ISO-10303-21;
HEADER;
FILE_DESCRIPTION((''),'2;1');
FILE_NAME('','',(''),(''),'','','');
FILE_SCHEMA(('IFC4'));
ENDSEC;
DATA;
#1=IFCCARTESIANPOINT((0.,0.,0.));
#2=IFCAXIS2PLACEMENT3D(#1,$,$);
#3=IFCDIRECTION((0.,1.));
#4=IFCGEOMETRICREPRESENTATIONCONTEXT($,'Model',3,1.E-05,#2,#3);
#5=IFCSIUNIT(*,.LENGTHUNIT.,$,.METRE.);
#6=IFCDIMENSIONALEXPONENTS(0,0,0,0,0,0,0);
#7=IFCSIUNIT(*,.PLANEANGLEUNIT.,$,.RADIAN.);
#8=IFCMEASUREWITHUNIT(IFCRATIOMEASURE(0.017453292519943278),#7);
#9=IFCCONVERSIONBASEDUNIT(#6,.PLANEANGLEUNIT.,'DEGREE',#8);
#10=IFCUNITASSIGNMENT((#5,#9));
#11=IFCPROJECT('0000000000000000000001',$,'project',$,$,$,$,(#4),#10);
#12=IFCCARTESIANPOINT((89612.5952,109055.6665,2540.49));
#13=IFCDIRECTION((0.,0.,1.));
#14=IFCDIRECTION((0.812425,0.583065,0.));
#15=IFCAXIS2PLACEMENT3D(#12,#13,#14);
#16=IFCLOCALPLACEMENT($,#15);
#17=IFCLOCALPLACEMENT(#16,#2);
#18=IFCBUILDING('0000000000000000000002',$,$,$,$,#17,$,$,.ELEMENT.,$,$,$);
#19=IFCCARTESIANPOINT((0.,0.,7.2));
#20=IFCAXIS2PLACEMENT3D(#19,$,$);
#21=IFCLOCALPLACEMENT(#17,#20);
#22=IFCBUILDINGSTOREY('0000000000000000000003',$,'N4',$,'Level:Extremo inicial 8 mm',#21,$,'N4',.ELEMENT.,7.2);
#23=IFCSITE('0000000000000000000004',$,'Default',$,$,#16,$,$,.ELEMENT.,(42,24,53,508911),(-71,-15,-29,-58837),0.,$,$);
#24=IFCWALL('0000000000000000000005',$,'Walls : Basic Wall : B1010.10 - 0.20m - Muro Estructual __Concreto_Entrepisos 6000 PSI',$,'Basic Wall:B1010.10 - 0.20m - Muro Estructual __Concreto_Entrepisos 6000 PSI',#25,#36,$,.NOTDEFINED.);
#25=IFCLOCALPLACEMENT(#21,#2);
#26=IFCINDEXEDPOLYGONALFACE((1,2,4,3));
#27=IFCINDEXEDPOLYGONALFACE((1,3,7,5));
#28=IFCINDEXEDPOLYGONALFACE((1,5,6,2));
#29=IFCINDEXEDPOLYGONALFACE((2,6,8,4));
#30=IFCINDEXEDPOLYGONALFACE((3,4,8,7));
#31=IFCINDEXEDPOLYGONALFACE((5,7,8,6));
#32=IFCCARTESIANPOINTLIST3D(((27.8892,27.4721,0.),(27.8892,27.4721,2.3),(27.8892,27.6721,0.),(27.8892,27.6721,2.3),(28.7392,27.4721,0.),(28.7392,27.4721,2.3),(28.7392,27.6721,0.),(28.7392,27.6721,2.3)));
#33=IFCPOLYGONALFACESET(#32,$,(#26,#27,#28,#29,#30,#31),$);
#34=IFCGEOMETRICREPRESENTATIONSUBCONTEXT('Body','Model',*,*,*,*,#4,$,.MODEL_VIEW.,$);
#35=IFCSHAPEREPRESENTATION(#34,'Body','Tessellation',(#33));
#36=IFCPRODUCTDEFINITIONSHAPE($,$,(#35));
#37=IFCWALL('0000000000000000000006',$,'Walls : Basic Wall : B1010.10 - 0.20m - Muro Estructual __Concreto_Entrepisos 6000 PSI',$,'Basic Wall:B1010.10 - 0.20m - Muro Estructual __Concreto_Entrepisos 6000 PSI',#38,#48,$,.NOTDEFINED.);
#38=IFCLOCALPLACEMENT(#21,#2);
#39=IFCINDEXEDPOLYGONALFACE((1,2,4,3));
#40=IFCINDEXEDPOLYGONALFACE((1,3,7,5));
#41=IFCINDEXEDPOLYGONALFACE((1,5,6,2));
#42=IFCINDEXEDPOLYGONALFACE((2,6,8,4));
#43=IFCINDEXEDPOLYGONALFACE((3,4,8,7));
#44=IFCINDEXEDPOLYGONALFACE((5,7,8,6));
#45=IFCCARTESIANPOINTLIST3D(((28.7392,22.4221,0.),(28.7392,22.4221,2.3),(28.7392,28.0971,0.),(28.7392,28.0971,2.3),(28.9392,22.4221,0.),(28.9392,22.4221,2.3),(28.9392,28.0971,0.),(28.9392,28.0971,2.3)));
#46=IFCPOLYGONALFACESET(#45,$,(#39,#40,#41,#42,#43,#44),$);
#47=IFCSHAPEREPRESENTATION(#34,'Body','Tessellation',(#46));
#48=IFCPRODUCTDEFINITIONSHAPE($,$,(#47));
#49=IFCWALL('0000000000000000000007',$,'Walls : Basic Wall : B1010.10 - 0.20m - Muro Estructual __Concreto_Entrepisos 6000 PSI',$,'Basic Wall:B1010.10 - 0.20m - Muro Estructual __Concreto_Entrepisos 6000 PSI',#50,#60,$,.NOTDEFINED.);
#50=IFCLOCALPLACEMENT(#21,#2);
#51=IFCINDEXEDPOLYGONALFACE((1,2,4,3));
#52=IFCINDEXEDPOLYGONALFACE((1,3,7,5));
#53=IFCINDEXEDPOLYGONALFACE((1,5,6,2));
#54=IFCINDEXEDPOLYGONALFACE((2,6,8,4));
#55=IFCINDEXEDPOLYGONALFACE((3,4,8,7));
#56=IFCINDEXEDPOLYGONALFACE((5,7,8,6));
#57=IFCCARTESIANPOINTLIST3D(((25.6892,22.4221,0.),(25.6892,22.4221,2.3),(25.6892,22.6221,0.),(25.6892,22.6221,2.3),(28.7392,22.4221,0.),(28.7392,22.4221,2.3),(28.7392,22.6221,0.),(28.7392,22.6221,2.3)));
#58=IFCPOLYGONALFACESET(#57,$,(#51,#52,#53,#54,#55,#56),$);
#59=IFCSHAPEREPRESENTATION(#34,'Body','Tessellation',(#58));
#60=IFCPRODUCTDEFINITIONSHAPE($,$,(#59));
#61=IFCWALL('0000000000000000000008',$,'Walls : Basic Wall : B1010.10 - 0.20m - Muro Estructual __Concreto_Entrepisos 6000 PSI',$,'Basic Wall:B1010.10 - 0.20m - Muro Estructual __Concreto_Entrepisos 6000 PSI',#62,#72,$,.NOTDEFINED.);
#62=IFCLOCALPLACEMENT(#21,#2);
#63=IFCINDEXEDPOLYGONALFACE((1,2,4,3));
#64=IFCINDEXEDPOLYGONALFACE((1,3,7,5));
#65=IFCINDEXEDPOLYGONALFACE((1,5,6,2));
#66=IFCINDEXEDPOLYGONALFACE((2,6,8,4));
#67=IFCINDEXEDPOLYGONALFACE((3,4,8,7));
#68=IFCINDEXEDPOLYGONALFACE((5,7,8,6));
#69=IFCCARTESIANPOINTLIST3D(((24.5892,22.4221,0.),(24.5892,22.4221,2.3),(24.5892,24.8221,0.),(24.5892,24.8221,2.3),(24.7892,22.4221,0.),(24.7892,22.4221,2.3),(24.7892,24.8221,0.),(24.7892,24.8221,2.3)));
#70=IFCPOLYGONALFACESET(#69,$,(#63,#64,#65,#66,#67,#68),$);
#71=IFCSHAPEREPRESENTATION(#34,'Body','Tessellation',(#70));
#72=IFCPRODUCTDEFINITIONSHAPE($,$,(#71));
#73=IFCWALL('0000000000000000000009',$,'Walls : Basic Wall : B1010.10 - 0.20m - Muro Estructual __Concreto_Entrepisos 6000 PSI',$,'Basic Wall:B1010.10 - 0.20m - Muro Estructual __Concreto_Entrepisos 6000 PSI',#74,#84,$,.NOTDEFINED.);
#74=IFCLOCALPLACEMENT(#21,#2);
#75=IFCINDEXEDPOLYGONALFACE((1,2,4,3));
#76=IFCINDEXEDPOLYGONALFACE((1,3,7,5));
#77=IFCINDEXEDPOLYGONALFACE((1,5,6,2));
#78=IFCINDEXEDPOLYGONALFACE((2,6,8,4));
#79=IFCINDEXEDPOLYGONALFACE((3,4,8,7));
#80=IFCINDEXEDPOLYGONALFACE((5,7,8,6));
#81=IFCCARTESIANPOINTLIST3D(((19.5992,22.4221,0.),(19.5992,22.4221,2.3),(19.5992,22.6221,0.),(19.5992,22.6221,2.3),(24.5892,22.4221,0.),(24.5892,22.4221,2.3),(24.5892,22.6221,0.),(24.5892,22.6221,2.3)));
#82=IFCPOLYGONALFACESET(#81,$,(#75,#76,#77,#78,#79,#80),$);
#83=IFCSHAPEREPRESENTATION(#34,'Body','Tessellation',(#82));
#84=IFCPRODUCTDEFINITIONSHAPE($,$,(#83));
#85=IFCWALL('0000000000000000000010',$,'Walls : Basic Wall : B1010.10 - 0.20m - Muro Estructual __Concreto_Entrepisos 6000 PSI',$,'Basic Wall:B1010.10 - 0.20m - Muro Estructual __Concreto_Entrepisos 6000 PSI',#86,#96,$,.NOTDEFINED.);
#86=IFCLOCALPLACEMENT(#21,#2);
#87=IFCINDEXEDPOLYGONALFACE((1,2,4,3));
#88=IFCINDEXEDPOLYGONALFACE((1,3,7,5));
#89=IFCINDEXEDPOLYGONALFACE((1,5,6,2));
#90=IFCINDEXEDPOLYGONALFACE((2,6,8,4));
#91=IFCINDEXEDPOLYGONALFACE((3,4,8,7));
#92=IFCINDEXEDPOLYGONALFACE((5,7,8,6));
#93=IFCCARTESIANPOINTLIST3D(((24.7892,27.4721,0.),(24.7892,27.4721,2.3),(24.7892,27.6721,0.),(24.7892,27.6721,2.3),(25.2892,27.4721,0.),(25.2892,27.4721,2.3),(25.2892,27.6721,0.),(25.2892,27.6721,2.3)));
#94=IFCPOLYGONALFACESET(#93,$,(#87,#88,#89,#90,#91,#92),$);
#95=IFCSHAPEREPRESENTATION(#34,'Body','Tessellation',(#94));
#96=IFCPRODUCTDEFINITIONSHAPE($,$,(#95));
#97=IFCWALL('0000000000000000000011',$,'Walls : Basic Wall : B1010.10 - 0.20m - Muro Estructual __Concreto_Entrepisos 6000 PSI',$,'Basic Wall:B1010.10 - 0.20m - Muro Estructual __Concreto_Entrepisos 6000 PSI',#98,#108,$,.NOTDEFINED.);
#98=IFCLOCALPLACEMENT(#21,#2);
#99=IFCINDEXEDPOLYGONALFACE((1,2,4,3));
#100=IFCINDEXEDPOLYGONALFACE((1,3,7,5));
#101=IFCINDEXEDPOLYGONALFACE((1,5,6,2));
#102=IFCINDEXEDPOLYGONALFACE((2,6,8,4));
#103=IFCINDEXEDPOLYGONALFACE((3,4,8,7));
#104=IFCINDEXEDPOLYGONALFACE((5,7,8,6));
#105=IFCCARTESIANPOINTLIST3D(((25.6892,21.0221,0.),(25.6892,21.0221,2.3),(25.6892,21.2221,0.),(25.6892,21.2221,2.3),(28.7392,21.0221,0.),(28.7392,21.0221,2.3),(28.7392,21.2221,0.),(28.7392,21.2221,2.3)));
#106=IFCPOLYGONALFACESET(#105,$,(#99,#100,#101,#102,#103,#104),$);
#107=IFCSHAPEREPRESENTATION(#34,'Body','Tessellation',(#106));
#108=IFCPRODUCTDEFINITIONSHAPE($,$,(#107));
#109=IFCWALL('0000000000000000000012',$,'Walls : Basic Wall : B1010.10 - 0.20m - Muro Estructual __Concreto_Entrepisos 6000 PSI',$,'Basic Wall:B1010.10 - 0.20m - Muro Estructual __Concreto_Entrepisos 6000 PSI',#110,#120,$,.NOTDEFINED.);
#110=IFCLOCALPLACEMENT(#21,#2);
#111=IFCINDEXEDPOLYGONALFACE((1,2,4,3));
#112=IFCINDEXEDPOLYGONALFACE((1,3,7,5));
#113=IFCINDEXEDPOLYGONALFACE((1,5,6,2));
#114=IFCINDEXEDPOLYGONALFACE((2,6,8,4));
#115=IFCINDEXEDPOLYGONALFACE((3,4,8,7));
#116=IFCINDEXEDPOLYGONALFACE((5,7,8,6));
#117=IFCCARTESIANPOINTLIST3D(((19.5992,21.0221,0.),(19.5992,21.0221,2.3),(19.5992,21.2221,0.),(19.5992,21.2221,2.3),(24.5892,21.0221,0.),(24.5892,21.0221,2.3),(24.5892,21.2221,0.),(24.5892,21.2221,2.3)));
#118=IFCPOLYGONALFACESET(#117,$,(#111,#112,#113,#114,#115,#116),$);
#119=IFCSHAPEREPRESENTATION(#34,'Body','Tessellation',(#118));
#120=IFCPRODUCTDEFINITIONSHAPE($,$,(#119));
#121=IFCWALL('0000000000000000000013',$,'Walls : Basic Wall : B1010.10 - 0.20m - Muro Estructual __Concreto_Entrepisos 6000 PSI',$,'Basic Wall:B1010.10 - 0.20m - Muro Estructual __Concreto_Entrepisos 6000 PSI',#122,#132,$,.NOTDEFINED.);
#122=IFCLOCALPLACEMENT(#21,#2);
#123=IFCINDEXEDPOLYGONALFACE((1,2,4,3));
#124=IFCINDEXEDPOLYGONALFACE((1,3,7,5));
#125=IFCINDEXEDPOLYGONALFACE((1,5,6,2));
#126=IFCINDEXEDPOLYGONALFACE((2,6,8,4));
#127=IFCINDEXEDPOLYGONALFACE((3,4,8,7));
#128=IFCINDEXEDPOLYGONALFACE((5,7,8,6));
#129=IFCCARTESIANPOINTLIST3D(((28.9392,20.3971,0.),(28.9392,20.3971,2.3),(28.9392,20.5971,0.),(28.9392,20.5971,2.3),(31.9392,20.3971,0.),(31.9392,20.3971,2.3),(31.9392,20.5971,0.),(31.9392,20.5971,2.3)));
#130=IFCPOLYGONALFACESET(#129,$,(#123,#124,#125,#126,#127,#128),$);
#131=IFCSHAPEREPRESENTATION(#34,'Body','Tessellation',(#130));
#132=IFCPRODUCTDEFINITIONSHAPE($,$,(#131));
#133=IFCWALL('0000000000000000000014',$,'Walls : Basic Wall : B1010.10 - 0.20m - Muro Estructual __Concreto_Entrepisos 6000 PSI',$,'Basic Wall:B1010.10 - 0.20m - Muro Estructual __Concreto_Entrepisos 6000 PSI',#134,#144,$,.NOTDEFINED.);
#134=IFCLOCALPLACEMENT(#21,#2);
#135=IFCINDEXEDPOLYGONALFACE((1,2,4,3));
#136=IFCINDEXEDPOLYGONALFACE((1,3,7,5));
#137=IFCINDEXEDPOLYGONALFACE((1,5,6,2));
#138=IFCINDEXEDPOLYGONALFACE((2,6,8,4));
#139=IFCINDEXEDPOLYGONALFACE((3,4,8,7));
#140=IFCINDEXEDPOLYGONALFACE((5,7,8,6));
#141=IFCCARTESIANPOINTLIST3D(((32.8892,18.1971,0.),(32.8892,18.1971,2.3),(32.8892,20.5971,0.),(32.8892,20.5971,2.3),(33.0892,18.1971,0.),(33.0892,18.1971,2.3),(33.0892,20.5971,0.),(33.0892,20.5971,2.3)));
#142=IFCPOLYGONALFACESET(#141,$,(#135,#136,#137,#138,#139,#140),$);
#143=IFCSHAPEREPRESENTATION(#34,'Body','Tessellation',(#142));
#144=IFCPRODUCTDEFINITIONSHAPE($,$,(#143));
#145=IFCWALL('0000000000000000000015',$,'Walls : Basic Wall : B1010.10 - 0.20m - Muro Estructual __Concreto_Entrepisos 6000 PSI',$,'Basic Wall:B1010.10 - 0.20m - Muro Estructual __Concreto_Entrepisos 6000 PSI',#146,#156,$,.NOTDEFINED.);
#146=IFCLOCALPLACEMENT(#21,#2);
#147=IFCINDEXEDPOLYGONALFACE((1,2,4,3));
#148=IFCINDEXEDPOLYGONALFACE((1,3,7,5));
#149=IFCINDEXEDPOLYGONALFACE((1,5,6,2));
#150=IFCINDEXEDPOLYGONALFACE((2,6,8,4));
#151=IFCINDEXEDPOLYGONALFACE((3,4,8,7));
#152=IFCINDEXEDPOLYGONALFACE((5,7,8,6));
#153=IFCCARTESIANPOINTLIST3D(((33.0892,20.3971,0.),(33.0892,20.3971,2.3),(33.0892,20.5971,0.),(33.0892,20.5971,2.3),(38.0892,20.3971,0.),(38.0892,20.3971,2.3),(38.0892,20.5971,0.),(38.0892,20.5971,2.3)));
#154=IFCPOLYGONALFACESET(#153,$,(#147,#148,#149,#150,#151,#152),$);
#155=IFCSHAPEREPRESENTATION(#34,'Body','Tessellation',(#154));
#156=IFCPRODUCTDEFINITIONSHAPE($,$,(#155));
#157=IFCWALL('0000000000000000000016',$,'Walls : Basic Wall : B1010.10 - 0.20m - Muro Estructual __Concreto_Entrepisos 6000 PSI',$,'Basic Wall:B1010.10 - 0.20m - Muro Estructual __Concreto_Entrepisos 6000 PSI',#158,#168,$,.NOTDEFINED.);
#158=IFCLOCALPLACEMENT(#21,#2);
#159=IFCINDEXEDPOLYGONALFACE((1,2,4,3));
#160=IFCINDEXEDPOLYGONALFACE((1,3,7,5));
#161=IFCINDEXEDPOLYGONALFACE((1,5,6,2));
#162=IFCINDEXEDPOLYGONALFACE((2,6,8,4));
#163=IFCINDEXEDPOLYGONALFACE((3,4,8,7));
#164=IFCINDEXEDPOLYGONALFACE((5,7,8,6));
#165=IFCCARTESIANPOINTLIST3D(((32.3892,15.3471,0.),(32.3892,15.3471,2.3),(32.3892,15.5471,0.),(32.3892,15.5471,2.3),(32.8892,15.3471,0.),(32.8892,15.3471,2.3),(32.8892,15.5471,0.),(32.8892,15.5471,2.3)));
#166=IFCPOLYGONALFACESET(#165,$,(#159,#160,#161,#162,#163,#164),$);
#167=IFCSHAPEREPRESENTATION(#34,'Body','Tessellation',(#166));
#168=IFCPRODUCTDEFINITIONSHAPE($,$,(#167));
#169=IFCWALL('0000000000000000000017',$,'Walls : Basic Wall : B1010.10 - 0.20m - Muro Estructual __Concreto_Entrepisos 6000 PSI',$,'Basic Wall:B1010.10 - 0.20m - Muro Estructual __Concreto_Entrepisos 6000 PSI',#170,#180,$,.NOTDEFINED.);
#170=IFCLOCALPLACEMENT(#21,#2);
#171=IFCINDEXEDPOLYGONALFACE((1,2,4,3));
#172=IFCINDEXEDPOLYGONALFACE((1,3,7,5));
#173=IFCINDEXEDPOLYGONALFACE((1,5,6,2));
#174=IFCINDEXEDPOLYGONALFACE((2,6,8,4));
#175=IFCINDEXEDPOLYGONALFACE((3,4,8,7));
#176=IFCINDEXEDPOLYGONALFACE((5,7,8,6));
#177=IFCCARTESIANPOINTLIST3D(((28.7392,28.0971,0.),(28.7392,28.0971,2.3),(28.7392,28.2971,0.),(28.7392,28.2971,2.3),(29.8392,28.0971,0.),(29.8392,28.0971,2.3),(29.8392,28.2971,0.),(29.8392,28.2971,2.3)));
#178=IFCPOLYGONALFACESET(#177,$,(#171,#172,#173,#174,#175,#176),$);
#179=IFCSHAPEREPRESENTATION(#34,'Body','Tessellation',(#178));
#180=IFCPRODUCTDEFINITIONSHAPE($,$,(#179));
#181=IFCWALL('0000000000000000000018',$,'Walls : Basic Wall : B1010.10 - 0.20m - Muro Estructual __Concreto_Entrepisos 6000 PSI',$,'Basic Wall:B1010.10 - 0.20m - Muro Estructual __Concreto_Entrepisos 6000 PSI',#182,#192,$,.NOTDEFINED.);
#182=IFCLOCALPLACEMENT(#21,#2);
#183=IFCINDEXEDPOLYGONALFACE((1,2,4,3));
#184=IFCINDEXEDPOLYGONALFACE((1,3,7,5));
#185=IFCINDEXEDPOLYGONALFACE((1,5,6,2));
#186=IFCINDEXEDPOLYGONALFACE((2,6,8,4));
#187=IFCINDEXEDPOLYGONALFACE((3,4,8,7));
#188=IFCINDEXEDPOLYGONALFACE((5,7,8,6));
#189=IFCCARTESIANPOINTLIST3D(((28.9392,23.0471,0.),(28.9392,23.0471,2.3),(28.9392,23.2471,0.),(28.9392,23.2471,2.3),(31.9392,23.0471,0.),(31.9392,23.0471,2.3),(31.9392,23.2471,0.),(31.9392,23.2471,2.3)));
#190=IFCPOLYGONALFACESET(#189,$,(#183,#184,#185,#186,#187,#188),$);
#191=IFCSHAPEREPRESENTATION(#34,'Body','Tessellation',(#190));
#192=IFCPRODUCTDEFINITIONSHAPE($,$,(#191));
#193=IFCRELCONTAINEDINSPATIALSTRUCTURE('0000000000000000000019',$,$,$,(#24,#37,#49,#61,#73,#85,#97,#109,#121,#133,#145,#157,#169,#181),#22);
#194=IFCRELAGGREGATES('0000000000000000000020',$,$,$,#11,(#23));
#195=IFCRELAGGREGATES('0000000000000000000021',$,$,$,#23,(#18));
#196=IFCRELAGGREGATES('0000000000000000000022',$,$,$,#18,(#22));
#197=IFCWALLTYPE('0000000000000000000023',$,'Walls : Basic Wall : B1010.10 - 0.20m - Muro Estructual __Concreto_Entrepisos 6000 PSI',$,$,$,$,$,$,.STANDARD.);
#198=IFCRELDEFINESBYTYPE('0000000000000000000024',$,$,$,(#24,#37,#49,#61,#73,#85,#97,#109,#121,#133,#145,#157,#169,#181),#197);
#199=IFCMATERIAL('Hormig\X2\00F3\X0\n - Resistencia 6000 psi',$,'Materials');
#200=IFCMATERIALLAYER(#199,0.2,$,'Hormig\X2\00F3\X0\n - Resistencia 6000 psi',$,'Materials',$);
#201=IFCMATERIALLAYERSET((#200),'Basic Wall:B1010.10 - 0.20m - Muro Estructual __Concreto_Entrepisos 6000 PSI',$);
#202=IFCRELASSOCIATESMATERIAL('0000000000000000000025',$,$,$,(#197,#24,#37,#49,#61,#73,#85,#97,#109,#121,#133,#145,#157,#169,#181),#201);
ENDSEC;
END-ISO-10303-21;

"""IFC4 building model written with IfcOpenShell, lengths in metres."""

from ifc_helpers import new_model, entity, si_unit, converted_unit, direction, frame, frame_2d, origin, place, context, subcontext, project, spatial, rectangle, extrude, material, layer, layer_set, layer_usage, type_object, element, save


model = new_model("IFC4")

# Units and contexts
model_context = context("Model", 3, precision=1e-05, world=origin(), true_north=direction((0.0, 1.0)))
body_context = subcontext(model_context, "Body", "Model", "MODEL_VIEW")
ifc_project = project(units=[si_unit("LENGTHUNIT", "METRE"), converted_unit("PLANEANGLEUNIT", "DEGREE", entity("IfcRatioMeasure", 0.017453292519943278), si_unit("PLANEANGLEUNIT", "RADIAN"), dimensions=[0, 0, 0, 0, 0, 0, 0])], contexts=[model_context])

# Site, building, storey
site_placement = place(None, frame((89612.5952, 109055.6665, 2540.49), z_axis=(0.0, 0.0, 1.0), x_axis=(0.812425, 0.583065, 0.0)))
site = spatial("IfcSite", under=ifc_project, at=site_placement, Name="Default", CompositionType="ELEMENT", RefLatitude=(42, 24, 53, 508911), RefLongitude=(-71, -15, -29, -58837), RefElevation=0.0)
building_placement = place(site_placement, origin())
building = spatial("IfcBuilding", under=site, at=building_placement, CompositionType="ELEMENT")
storey_placement = place(building_placement, frame((0.0, 0.0, 7.2)))
storey = spatial("IfcBuildingStorey", under=building, at=storey_placement, Name="N4", ObjectType="Level:Extremo inicial 8 mm", LongName="N4", CompositionType="ELEMENT", Elevation=7.2)

# Walls
ifc_material = material(Name="Hormigón - Resistencia 6000 psi", Category="Materials")
ifc_layer_1 = layer(ifc_material, 0.2, Name="Hormigón - Resistencia 6000 psi", Category="Materials")
ifc_layer_set_1 = layer_set([ifc_layer_1], Name="Basic Wall:B1010.10 - 0.20m - Muro Estructual __Concreto_Entrepisos 6000 PSI")
ifc_layer_usage_1 = layer_usage(ifc_layer_set_1, "AXIS2", "NEGATIVE", 0.1)
wall_type_1 = type_object("IfcWallType", Name="Walls : Basic Wall : B1010.10 - 0.20m - Muro Estructual __Concreto_Entrepisos 6000 PSI", PredefinedType="STANDARD", material=ifc_layer_set_1)
wall_1_placement = place(storey_placement, frame((27.8892, 27.5721, 0.0)))
element("IfcWall", 1, at=wall_1_placement, inside=storey, type_object=wall_type_1, material=ifc_layer_usage_1, Name="Walls : Basic Wall : B1010.10 - 0.20m - Muro Estructual __Concreto_Entrepisos 6000 PSI", ObjectType="Basic Wall:B1010.10 - 0.20m - Muro Estructual __Concreto_Entrepisos 6000 PSI", PredefinedType="NOTDEFINED", context=body_context, shape_type="SweptSolid", body=[
    extrude(rectangle(XDim=0.85, YDim=0.2, at=frame_2d((0.425, 0.0), x_axis=(-1.0, 0.0))), origin(), (0.0, 0.0, 1.0), 2.3),
])
ifc_layer_usage_2 = layer_usage(ifc_layer_set_1, "AXIS2", "NEGATIVE", 0.1)
wall_2_placement = place(storey_placement, frame((28.8392, 28.0971, 0.0), z_axis=(0.0, 0.0, 1.0), x_axis=(0.0, -1.0, 0.0)))
element("IfcWall", 2, at=wall_2_placement, inside=storey, type_object=wall_type_1, material=ifc_layer_usage_2, Name="Walls : Basic Wall : B1010.10 - 0.20m - Muro Estructual __Concreto_Entrepisos 6000 PSI", ObjectType="Basic Wall:B1010.10 - 0.20m - Muro Estructual __Concreto_Entrepisos 6000 PSI", PredefinedType="NOTDEFINED", context=body_context, shape_type="SweptSolid", body=[
    extrude(rectangle(XDim=5.675, YDim=0.2, at=frame_2d((2.8375, 0.0), x_axis=(-1.0, 0.0))), origin(), (0.0, 0.0, 1.0), 2.3),
])
ifc_layer_usage_3 = layer_usage(ifc_layer_set_1, "AXIS2", "NEGATIVE", 0.1)
wall_3_placement = place(storey_placement, frame((28.7392, 22.5221, 0.0), z_axis=(0.0, 0.0, 1.0), x_axis=(-1.0, 0.0, 0.0)))
element("IfcWall", 3, at=wall_3_placement, inside=storey, type_object=wall_type_1, material=ifc_layer_usage_3, Name="Walls : Basic Wall : B1010.10 - 0.20m - Muro Estructual __Concreto_Entrepisos 6000 PSI", ObjectType="Basic Wall:B1010.10 - 0.20m - Muro Estructual __Concreto_Entrepisos 6000 PSI", PredefinedType="NOTDEFINED", context=body_context, shape_type="SweptSolid", body=[
    extrude(rectangle(XDim=3.05, YDim=0.2, at=frame_2d((1.525, 0.0), x_axis=(-1.0, 0.0))), origin(), (0.0, 0.0, 1.0), 2.3),
])
ifc_layer_usage_4 = layer_usage(ifc_layer_set_1, "AXIS2", "NEGATIVE", 0.1)
wall_4_placement = place(storey_placement, frame((24.6892, 24.8221, 0.0), z_axis=(0.0, 0.0, 1.0), x_axis=(0.0, -1.0, 0.0)))
element("IfcWall", 4, at=wall_4_placement, inside=storey, type_object=wall_type_1, material=ifc_layer_usage_4, Name="Walls : Basic Wall : B1010.10 - 0.20m - Muro Estructual __Concreto_Entrepisos 6000 PSI", ObjectType="Basic Wall:B1010.10 - 0.20m - Muro Estructual __Concreto_Entrepisos 6000 PSI", PredefinedType="NOTDEFINED", context=body_context, shape_type="SweptSolid", body=[
    extrude(rectangle(XDim=2.4, YDim=0.2, at=frame_2d((1.2, 0.0), x_axis=(-1.0, 0.0))), origin(), (0.0, 0.0, 1.0), 2.3),
])
ifc_layer_usage_5 = layer_usage(ifc_layer_set_1, "AXIS2", "NEGATIVE", 0.1)
wall_5_placement = place(storey_placement, frame((24.5892, 22.5221, 0.0), z_axis=(0.0, 0.0, 1.0), x_axis=(-1.0, 0.0, 0.0)))
element("IfcWall", 5, at=wall_5_placement, inside=storey, type_object=wall_type_1, material=ifc_layer_usage_5, Name="Walls : Basic Wall : B1010.10 - 0.20m - Muro Estructual __Concreto_Entrepisos 6000 PSI", ObjectType="Basic Wall:B1010.10 - 0.20m - Muro Estructual __Concreto_Entrepisos 6000 PSI", PredefinedType="NOTDEFINED", context=body_context, shape_type="SweptSolid", body=[
    extrude(rectangle(XDim=4.99, YDim=0.2, at=frame_2d((2.495, 0.0), x_axis=(-1.0, 0.0))), origin(), (0.0, 0.0, 1.0), 2.3),
])
ifc_layer_usage_6 = layer_usage(ifc_layer_set_1, "AXIS2", "NEGATIVE", 0.1)
wall_6_placement = place(storey_placement, frame((25.2892, 27.5721, 0.0), z_axis=(0.0, 0.0, 1.0), x_axis=(-1.0, 0.0, 0.0)))
element("IfcWall", 6, at=wall_6_placement, inside=storey, type_object=wall_type_1, material=ifc_layer_usage_6, Name="Walls : Basic Wall : B1010.10 - 0.20m - Muro Estructual __Concreto_Entrepisos 6000 PSI", ObjectType="Basic Wall:B1010.10 - 0.20m - Muro Estructual __Concreto_Entrepisos 6000 PSI", PredefinedType="NOTDEFINED", context=body_context, shape_type="SweptSolid", body=[
    extrude(rectangle(XDim=0.5, YDim=0.2, at=frame_2d((0.25, 0.0), x_axis=(-1.0, 0.0))), origin(), (0.0, 0.0, 1.0), 2.3),
])
ifc_layer_usage_7 = layer_usage(ifc_layer_set_1, "AXIS2", "POSITIVE", -0.1)
wall_7_placement = place(storey_placement, frame((28.7392, 21.1221, 0.0), z_axis=(0.0, 0.0, 1.0), x_axis=(-1.0, 0.0, 0.0)))
element("IfcWall", 7, at=wall_7_placement, inside=storey, type_object=wall_type_1, material=ifc_layer_usage_7, Name="Walls : Basic Wall : B1010.10 - 0.20m - Muro Estructual __Concreto_Entrepisos 6000 PSI", ObjectType="Basic Wall:B1010.10 - 0.20m - Muro Estructual __Concreto_Entrepisos 6000 PSI", PredefinedType="NOTDEFINED", context=body_context, shape_type="SweptSolid", body=[
    extrude(rectangle(XDim=3.05, YDim=0.2, at=frame_2d((1.525, 0.0), x_axis=(-1.0, 0.0))), origin(), (0.0, 0.0, 1.0), 2.3),
])
ifc_layer_usage_8 = layer_usage(ifc_layer_set_1, "AXIS2", "POSITIVE", -0.1)
wall_8_placement = place(storey_placement, frame((24.5892, 21.1221, 0.0), z_axis=(0.0, 0.0, 1.0), x_axis=(-1.0, 0.0, 0.0)))
element("IfcWall", 8, at=wall_8_placement, inside=storey, type_object=wall_type_1, material=ifc_layer_usage_8, Name="Walls : Basic Wall : B1010.10 - 0.20m - Muro Estructual __Concreto_Entrepisos 6000 PSI", ObjectType="Basic Wall:B1010.10 - 0.20m - Muro Estructual __Concreto_Entrepisos 6000 PSI", PredefinedType="NOTDEFINED", context=body_context, shape_type="SweptSolid", body=[
    extrude(rectangle(XDim=4.99, YDim=0.2, at=frame_2d((2.495, 0.0), x_axis=(-1.0, 0.0))), origin(), (0.0, 0.0, 1.0), 2.3),
])
ifc_layer_usage_9 = layer_usage(ifc_layer_set_1, "AXIS2", "NEGATIVE", 0.1)
wall_9_placement = place(storey_placement, frame((28.9392, 20.4971, 0.0)))
element("IfcWall", 9, at=wall_9_placement, inside=storey, type_object=wall_type_1, material=ifc_layer_usage_9, Name="Walls : Basic Wall : B1010.10 - 0.20m - Muro Estructual __Concreto_Entrepisos 6000 PSI", ObjectType="Basic Wall:B1010.10 - 0.20m - Muro Estructual __Concreto_Entrepisos 6000 PSI", PredefinedType="NOTDEFINED", context=body_context, shape_type="SweptSolid", body=[
    extrude(rectangle(XDim=3.0, YDim=0.2, at=frame_2d((1.5, 0.0), x_axis=(-1.0, 0.0))), origin(), (0.0, 0.0, 1.0), 2.3),
])
ifc_layer_usage_10 = layer_usage(ifc_layer_set_1, "AXIS2", "NEGATIVE", 0.1)
wall_10_placement = place(storey_placement, frame((32.9892, 18.1971, 0.0), z_axis=(0.0, 0.0, 1.0), x_axis=(0.0, 1.0, 0.0)))
element("IfcWall", 10, at=wall_10_placement, inside=storey, type_object=wall_type_1, material=ifc_layer_usage_10, Name="Walls : Basic Wall : B1010.10 - 0.20m - Muro Estructual __Concreto_Entrepisos 6000 PSI", ObjectType="Basic Wall:B1010.10 - 0.20m - Muro Estructual __Concreto_Entrepisos 6000 PSI", PredefinedType="NOTDEFINED", context=body_context, shape_type="SweptSolid", body=[
    extrude(rectangle(XDim=2.4, YDim=0.2, at=frame_2d((1.2, 0.0), x_axis=(-1.0, 0.0))), origin(), (0.0, 0.0, 1.0), 2.3),
])
ifc_layer_usage_11 = layer_usage(ifc_layer_set_1, "AXIS2", "NEGATIVE", 0.1)
wall_11_placement = place(storey_placement, frame((33.0892, 20.4971, 0.0)))
element("IfcWall", 11, at=wall_11_placement, inside=storey, type_object=wall_type_1, material=ifc_layer_usage_11, Name="Walls : Basic Wall : B1010.10 - 0.20m - Muro Estructual __Concreto_Entrepisos 6000 PSI", ObjectType="Basic Wall:B1010.10 - 0.20m - Muro Estructual __Concreto_Entrepisos 6000 PSI", PredefinedType="NOTDEFINED", context=body_context, shape_type="SweptSolid", body=[
    extrude(rectangle(XDim=5.0, YDim=0.2, at=frame_2d((2.5, 0.0), x_axis=(-1.0, 0.0))), origin(), (0.0, 0.0, 1.0), 2.3),
])
ifc_layer_usage_12 = layer_usage(ifc_layer_set_1, "AXIS2", "NEGATIVE", 0.1)
wall_12_placement = place(storey_placement, frame((32.3892, 15.4471, 0.0)))
element("IfcWall", 12, at=wall_12_placement, inside=storey, type_object=wall_type_1, material=ifc_layer_usage_12, Name="Walls : Basic Wall : B1010.10 - 0.20m - Muro Estructual __Concreto_Entrepisos 6000 PSI", ObjectType="Basic Wall:B1010.10 - 0.20m - Muro Estructual __Concreto_Entrepisos 6000 PSI", PredefinedType="NOTDEFINED", context=body_context, shape_type="SweptSolid", body=[
    extrude(rectangle(XDim=0.5, YDim=0.2, at=frame_2d((0.25, 0.0), x_axis=(-1.0, 0.0))), origin(), (0.0, 0.0, 1.0), 2.3),
])
ifc_layer_usage_13 = layer_usage(ifc_layer_set_1, "AXIS2", "POSITIVE", -0.1)
wall_13_placement = place(storey_placement, frame((29.8392, 28.1971, 0.0), z_axis=(0.0, 0.0, 1.0), x_axis=(-1.0, 0.0, 0.0)))
element("IfcWall", 13, at=wall_13_placement, inside=storey, type_object=wall_type_1, material=ifc_layer_usage_13, Name="Walls : Basic Wall : B1010.10 - 0.20m - Muro Estructual __Concreto_Entrepisos 6000 PSI", ObjectType="Basic Wall:B1010.10 - 0.20m - Muro Estructual __Concreto_Entrepisos 6000 PSI", PredefinedType="NOTDEFINED", context=body_context, shape_type="SweptSolid", body=[
    extrude(rectangle(XDim=1.1, YDim=0.2, at=frame_2d((0.55, 0.0), x_axis=(-1.0, 0.0))), origin(), (0.0, 0.0, 1.0), 2.3),
])
ifc_layer_usage_14 = layer_usage(ifc_layer_set_1, "AXIS2", "POSITIVE", -0.1)
wall_14_placement = place(storey_placement, frame((28.9392, 23.1471, 0.0)))
element("IfcWall", 14, at=wall_14_placement, inside=storey, type_object=wall_type_1, material=ifc_layer_usage_14, Name="Walls : Basic Wall : B1010.10 - 0.20m - Muro Estructual __Concreto_Entrepisos 6000 PSI", ObjectType="Basic Wall:B1010.10 - 0.20m - Muro Estructual __Concreto_Entrepisos 6000 PSI", PredefinedType="NOTDEFINED", context=body_context, shape_type="SweptSolid", body=[
    extrude(rectangle(XDim=3.0, YDim=0.2, at=frame_2d((1.5, 0.0), x_axis=(-1.0, 0.0))), origin(), (0.0, 0.0, 1.0), 2.3),
])

save(model, "model.ifc")
